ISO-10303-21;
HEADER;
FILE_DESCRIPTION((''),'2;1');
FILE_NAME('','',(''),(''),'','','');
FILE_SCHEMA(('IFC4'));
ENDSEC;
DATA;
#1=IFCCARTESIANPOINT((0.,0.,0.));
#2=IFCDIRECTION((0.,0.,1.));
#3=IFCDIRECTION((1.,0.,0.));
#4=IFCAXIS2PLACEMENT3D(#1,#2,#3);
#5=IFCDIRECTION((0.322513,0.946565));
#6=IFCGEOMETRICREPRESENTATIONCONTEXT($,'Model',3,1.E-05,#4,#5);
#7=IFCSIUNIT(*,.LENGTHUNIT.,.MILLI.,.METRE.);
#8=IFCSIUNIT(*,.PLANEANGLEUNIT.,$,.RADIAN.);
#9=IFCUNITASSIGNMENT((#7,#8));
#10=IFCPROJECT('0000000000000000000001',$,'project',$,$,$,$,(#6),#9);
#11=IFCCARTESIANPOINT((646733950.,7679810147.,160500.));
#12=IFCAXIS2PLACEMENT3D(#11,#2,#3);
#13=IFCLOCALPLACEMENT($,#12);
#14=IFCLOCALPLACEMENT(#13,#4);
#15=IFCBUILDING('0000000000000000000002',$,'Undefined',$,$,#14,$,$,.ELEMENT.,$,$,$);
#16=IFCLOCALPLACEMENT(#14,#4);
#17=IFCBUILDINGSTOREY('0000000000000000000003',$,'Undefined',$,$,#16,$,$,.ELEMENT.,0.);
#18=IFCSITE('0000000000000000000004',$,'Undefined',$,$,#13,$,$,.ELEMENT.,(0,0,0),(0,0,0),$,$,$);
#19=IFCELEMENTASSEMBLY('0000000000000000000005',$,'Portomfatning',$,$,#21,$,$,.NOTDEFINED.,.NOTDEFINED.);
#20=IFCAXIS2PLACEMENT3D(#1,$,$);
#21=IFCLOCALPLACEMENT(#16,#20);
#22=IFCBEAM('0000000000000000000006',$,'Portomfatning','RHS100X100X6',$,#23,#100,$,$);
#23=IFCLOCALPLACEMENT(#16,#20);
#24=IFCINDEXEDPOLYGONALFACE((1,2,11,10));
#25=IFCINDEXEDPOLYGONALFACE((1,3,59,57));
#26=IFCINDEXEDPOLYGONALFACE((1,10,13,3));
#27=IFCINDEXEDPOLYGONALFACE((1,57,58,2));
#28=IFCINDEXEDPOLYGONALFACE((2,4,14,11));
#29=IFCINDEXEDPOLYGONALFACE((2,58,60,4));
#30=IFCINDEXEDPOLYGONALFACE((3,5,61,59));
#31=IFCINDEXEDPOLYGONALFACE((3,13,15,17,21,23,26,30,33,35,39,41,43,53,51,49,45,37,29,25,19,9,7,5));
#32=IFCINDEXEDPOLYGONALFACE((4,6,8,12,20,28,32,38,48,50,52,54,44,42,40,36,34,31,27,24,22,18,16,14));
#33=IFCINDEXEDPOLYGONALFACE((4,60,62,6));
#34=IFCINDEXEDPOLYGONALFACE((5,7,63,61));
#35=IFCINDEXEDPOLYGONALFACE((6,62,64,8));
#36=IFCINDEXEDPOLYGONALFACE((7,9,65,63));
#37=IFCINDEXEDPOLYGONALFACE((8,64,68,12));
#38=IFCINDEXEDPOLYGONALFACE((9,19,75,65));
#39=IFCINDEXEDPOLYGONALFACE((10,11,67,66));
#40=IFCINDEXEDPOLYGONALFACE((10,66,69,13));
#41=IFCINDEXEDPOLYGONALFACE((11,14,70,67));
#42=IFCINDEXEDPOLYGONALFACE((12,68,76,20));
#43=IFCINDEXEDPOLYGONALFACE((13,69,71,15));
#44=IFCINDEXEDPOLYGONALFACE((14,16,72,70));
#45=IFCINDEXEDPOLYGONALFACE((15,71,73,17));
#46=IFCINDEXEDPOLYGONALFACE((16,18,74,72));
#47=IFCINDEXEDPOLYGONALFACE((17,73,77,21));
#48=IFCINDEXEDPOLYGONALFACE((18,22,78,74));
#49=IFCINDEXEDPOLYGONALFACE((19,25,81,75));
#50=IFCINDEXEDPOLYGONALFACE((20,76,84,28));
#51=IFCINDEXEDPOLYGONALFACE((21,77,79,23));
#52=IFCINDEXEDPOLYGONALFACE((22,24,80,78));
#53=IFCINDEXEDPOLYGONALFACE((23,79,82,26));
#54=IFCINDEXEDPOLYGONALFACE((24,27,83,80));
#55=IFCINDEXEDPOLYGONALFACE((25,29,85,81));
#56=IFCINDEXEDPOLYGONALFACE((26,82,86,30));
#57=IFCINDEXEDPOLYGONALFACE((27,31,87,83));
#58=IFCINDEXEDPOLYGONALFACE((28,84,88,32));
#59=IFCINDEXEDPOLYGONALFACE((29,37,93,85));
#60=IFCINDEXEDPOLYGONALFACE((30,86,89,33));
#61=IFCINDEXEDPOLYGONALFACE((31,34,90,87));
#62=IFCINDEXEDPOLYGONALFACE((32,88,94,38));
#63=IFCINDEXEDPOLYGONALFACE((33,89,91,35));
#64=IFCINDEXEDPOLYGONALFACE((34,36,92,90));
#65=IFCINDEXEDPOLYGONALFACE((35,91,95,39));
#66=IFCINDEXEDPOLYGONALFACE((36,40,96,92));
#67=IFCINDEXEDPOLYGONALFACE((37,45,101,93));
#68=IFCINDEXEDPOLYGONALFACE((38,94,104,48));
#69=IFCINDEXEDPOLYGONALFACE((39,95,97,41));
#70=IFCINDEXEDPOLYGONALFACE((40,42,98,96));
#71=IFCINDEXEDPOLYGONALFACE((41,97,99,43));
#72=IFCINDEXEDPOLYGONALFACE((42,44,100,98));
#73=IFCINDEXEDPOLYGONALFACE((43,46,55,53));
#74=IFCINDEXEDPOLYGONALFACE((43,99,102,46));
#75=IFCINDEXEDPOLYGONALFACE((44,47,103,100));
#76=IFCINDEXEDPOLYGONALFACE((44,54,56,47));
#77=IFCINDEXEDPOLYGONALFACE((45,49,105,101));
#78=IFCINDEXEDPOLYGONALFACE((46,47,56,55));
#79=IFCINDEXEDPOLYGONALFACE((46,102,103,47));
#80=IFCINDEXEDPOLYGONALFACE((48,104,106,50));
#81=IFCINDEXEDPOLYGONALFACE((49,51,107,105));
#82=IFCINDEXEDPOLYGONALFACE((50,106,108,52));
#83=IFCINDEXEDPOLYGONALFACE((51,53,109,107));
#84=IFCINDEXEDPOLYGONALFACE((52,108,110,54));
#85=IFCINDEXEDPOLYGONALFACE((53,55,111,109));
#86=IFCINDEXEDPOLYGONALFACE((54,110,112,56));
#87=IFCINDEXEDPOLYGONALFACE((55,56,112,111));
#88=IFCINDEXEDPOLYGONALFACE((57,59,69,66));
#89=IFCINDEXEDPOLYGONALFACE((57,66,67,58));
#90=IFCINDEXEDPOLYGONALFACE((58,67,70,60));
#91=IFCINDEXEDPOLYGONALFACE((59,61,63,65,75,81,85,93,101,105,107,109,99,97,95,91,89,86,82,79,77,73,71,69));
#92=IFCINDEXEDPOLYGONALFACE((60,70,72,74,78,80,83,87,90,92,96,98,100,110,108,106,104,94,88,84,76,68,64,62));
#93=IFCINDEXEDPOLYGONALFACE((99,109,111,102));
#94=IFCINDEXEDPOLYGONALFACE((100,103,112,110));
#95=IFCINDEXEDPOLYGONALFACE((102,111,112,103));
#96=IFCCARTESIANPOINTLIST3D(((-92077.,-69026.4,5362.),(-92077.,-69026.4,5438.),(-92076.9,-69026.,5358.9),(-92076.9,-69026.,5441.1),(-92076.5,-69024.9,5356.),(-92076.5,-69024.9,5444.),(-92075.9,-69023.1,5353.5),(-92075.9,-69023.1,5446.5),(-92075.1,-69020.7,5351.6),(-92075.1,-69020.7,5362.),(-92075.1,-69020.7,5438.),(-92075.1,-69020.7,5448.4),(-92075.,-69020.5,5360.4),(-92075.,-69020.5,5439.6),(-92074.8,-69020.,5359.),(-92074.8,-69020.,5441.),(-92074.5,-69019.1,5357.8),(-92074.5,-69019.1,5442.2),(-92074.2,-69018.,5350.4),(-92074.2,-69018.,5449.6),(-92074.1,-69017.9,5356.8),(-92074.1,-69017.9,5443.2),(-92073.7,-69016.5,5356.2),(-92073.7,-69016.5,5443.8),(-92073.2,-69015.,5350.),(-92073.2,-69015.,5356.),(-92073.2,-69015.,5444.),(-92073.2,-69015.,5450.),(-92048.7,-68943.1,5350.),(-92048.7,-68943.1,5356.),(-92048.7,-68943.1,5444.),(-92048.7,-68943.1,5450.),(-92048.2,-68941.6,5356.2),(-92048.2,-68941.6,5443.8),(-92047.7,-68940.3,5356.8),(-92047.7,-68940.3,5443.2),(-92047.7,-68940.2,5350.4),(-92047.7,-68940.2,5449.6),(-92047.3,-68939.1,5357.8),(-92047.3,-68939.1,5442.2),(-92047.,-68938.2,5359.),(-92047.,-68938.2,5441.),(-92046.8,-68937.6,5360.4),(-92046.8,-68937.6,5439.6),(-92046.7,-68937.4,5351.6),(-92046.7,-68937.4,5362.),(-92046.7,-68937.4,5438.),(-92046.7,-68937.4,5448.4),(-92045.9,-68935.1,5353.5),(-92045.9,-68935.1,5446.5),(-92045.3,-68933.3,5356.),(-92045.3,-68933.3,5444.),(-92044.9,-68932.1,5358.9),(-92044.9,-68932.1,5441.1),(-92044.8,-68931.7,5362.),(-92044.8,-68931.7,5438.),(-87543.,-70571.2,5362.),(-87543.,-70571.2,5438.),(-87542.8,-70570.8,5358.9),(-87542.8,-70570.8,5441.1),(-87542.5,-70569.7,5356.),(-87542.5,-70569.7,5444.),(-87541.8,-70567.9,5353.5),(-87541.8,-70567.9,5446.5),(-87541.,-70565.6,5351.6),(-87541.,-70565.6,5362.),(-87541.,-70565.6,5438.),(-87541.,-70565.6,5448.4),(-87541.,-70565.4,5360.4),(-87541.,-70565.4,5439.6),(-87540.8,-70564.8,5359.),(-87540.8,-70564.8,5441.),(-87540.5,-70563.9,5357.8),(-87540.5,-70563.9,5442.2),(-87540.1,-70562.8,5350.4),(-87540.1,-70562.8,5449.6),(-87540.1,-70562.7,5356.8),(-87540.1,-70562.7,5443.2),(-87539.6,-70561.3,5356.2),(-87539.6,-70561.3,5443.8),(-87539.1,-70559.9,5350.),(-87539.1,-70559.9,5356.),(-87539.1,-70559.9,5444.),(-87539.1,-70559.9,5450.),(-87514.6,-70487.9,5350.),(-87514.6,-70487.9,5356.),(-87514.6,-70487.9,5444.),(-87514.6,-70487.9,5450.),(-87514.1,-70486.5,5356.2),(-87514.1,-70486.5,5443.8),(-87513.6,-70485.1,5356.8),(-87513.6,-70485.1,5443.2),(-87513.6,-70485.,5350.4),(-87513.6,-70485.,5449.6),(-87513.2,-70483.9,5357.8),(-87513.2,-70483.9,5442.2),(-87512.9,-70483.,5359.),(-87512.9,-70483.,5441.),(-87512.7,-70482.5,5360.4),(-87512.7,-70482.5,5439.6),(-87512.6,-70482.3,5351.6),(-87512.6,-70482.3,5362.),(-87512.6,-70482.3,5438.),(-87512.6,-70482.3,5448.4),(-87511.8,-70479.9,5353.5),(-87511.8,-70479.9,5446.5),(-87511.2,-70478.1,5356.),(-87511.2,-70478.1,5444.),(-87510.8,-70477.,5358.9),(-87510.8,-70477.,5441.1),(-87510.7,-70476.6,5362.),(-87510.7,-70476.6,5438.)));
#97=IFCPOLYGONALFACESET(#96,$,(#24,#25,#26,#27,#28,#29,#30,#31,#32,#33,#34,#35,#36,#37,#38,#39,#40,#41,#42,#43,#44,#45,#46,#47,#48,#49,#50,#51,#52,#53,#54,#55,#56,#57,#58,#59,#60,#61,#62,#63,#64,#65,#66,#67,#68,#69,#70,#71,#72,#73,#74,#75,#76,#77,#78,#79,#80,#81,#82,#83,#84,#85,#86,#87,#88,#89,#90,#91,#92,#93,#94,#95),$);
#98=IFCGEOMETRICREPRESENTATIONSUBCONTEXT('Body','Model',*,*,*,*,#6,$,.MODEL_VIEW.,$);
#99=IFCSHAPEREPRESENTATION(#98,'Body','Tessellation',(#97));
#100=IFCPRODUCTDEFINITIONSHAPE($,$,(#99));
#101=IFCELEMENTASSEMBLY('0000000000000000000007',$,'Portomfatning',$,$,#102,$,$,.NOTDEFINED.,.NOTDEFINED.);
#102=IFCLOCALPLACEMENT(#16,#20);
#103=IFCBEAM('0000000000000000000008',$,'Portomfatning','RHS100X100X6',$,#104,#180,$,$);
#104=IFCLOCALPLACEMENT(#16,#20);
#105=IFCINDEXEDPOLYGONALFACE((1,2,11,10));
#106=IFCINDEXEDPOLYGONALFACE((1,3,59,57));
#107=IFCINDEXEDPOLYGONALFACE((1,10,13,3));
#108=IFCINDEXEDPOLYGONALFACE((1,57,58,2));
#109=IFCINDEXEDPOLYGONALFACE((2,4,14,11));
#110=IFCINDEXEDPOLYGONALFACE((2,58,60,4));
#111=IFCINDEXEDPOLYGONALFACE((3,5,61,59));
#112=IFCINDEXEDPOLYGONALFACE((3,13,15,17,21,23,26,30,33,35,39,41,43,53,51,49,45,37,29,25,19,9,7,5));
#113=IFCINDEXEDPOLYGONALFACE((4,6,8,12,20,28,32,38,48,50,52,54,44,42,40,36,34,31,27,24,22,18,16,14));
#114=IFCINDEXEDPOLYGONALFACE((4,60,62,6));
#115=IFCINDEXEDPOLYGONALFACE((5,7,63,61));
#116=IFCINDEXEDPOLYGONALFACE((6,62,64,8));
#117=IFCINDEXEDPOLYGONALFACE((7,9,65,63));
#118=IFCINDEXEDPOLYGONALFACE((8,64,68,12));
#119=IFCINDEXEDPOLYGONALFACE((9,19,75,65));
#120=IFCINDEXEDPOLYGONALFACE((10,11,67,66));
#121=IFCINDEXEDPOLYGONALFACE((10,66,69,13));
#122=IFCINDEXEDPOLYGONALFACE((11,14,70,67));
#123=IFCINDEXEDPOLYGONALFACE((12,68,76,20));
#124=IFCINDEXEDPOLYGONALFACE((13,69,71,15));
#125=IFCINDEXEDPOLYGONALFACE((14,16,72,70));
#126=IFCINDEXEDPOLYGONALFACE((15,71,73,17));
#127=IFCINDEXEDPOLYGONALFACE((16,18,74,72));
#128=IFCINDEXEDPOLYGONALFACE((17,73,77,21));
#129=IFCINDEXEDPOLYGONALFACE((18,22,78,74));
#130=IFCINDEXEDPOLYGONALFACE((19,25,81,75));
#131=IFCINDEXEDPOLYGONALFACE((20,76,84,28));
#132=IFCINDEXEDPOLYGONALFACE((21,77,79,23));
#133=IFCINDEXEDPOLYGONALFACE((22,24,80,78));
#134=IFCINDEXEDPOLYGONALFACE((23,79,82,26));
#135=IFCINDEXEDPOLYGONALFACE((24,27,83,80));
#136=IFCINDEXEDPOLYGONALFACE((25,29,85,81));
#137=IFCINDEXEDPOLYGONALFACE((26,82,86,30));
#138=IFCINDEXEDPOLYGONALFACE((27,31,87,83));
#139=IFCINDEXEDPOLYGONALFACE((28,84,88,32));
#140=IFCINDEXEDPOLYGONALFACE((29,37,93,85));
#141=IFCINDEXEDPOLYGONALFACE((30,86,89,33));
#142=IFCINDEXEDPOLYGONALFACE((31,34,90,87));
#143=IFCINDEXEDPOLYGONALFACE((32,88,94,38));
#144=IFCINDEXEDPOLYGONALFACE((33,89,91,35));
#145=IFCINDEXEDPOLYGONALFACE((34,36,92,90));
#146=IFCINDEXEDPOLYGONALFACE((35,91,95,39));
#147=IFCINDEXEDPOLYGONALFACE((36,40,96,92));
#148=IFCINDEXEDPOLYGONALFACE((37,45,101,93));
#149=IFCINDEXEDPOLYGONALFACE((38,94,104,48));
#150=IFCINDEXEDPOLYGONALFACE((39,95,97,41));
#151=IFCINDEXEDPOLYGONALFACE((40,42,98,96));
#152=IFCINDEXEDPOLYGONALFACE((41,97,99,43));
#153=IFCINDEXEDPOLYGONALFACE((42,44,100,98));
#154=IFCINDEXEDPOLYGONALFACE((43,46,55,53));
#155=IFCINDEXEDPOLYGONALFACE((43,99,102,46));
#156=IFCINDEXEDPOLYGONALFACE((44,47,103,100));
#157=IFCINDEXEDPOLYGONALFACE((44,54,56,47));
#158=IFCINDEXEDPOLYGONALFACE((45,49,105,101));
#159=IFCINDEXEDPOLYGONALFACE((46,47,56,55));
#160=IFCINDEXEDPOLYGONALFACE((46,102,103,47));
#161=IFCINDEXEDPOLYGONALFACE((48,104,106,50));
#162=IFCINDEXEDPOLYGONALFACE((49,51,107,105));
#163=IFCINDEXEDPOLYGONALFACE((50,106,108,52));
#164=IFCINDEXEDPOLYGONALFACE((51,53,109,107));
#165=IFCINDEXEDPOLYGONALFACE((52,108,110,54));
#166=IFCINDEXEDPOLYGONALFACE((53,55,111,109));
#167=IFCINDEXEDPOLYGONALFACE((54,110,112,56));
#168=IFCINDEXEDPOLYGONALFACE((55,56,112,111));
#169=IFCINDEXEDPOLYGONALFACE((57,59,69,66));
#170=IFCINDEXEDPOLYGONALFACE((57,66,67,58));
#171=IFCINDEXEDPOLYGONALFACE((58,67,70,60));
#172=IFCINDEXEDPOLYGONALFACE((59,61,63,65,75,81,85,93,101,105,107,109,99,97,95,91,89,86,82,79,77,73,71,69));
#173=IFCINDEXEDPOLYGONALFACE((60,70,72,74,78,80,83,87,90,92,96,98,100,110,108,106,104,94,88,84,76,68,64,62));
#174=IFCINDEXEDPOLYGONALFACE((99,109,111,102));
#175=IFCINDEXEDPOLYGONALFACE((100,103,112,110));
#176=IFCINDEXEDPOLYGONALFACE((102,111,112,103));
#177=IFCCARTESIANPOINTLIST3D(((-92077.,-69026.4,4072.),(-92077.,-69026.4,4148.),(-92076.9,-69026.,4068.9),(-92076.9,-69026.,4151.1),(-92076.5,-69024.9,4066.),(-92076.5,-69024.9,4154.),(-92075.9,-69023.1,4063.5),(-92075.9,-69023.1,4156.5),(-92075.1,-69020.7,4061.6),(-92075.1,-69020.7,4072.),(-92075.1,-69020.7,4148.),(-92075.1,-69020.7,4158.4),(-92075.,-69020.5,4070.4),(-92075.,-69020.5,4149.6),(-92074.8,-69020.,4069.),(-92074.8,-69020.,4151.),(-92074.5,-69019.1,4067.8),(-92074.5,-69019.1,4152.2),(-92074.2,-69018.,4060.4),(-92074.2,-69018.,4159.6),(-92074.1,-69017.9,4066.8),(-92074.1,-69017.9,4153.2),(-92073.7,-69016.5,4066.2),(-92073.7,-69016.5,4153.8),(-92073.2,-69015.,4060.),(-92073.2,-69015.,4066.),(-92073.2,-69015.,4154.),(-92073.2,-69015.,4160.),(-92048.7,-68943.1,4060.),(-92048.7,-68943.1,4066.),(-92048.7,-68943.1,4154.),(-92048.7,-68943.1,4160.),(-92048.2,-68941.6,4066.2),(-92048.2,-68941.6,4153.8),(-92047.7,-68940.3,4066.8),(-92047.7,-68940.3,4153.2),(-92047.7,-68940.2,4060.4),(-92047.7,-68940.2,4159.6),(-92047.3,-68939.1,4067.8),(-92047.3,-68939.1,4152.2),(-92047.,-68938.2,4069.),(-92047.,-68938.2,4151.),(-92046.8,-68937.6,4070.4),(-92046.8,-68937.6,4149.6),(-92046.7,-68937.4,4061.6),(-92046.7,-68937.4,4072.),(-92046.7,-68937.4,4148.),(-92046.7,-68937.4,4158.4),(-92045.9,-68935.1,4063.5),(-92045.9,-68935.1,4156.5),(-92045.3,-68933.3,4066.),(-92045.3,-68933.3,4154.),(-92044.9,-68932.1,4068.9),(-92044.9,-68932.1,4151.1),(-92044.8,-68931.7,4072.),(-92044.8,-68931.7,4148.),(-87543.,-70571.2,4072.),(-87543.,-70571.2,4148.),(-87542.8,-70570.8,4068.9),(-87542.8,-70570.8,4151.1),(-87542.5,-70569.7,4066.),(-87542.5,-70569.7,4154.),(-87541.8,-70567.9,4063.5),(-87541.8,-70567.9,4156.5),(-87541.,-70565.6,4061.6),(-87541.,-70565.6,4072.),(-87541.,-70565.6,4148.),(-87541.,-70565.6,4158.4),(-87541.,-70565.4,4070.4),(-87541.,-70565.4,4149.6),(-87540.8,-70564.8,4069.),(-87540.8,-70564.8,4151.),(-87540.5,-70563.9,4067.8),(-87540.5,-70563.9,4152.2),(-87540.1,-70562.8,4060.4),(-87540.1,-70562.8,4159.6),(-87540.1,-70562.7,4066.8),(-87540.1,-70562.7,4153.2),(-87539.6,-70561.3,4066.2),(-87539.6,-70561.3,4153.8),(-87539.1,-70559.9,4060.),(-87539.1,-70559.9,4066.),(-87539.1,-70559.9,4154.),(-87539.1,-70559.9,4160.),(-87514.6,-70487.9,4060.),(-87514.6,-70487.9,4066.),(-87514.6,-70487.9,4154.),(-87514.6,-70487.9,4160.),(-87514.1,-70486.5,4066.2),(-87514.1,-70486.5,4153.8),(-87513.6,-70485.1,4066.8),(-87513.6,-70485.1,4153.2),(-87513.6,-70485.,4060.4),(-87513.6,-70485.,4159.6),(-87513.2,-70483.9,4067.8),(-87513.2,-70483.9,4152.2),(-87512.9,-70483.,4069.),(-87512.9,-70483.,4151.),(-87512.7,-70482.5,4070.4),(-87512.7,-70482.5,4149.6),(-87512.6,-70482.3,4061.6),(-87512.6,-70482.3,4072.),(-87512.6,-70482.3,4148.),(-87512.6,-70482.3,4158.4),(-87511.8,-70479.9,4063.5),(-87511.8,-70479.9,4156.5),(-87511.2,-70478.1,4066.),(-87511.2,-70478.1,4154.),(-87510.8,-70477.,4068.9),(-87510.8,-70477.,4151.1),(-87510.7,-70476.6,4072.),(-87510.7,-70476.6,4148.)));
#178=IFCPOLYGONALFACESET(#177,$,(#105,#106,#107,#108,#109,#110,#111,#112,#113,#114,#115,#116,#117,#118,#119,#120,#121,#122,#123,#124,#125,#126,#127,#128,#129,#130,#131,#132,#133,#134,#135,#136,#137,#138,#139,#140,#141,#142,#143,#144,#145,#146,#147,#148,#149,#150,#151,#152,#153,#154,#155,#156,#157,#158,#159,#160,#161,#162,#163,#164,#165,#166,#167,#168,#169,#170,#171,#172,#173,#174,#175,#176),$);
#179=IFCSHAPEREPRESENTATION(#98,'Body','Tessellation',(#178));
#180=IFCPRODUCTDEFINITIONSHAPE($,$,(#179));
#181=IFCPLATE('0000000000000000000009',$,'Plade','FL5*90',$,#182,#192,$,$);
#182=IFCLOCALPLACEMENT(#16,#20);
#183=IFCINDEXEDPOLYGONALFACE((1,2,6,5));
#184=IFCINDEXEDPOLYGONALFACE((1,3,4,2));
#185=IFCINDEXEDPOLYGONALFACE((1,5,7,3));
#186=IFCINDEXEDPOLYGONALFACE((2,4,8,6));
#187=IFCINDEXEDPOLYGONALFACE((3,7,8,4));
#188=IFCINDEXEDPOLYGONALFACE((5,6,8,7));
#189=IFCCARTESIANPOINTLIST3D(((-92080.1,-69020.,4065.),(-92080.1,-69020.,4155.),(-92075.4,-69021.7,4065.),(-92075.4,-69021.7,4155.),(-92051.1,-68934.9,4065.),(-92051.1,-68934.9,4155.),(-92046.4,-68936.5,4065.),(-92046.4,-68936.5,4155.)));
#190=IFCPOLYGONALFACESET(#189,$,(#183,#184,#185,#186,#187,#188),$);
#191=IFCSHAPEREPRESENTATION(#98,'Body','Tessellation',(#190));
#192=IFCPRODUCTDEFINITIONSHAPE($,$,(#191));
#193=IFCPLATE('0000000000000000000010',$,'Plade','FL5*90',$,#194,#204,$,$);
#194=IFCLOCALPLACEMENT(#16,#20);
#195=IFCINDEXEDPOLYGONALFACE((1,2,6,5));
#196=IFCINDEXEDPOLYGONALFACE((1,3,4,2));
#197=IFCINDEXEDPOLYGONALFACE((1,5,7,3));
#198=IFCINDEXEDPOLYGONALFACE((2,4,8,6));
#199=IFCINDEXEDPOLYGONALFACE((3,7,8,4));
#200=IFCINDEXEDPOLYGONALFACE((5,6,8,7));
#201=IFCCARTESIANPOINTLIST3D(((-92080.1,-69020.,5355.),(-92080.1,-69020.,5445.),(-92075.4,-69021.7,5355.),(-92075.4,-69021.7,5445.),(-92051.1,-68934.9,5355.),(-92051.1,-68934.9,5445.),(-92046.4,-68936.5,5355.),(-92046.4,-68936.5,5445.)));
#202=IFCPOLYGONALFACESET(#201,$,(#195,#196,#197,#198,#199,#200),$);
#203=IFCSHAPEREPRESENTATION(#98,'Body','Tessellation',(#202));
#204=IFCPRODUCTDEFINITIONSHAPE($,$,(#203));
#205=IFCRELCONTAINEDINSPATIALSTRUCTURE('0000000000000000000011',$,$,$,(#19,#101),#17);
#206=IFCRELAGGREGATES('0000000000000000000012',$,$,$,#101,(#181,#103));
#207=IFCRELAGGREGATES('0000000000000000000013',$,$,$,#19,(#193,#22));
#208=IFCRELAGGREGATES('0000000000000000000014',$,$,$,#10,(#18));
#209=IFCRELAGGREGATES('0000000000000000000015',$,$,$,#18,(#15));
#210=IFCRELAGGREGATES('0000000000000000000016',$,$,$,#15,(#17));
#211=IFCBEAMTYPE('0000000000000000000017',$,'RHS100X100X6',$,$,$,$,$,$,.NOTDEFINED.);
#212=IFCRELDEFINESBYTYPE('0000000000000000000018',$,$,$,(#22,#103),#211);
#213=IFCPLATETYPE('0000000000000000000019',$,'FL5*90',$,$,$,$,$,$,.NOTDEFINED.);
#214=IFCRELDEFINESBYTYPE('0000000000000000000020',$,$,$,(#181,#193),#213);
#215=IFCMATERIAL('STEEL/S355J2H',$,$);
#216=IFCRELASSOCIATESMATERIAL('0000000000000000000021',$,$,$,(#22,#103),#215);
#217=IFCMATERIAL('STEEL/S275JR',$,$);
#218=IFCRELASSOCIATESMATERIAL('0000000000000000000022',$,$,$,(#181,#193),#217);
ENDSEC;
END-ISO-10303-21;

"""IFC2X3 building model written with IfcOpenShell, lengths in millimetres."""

from ifc_helpers import new_model, si_unit, direction, frame, origin_with_axes, origin_2d_with_axis, place, context, subcontext, project, spatial, polyline, hollow_rectangle, outline, extrude, clip, halfspace, material, type_object, element, aggregate, save


model = new_model("IFC2X3")

# Units and contexts
model_context = context("Model", 3, precision=1e-05, world=origin_with_axes(), true_north=direction((0.322513, 0.946565)))
body_context = subcontext(model_context, "Body", "Model", "MODEL_VIEW")
ifc_project = project(units=[si_unit("LENGTHUNIT", "METRE", prefix="MILLI"), si_unit("PLANEANGLEUNIT", "RADIAN")], contexts=[model_context])

# Site, building, storey
site_placement = place(None, frame((646733950.0, 7679810147.0, 160500.0), z_axis=(0.0, 0.0, 1.0), x_axis=(1.0, 0.0, 0.0)))
site = spatial("IfcSite", under=ifc_project, at=site_placement, Name="Undefined", CompositionType="ELEMENT", RefLatitude=(0, 0, 0), RefLongitude=(0, 0, 0))
building_placement = place(site_placement, origin_with_axes())
building = spatial("IfcBuilding", under=site, at=building_placement, Name="Undefined", CompositionType="ELEMENT")
storey_placement = place(building_placement, origin_with_axes())
storey = spatial("IfcBuildingStorey", under=building, at=storey_placement, Name="Undefined", CompositionType="ELEMENT", Elevation=0.0)

# Shared definitions
ifc_material_1 = material(Name="STEEL/S355J2H")

# Element assemblies, beams
assembly_1_placement = place(storey_placement, origin_with_axes())
assembly_1 = element("IfcElementAssembly", 1, at=assembly_1_placement, inside=storey, Name="Portomfatning", AssemblyPlace="NOTDEFINED", PredefinedType="NOTDEFINED")
beam_type = type_object("IfcBeamType", Name="RHS100X100X6", PredefinedType="NOTDEFINED")
beam_1_placement = place(assembly_1_placement, frame((-92075.1, -68974.2, 5400.0), z_axis=(0.322513, 0.946565, 0.0), x_axis=(0.946565, -0.322513, 0.0)))
beam_1 = element("IfcBeam", 2, at=beam_1_placement, type_object=beam_type, material=ifc_material_1, Name="Portomfatning", Description="RHS100X100X6", context=body_context, shape_type="Clipping", body=[
    clip(clip(extrude(hollow_rectangle(XDim=100.0, YDim=100.0, WallThickness=6.0, InnerFilletRadius=6.0, OuterFilletRadius=12.0, at=origin_2d_with_axis()), frame((4866.7, 0.0, 0.0), z_axis=(-1.0, 0.0, 0.0), x_axis=(0.0, -1.0, 0.0)), (0.0, 0.0, 1.0), 4913.4), halfspace(frame((4805.0, -50.0, -50.0), z_axis=(-1.0, 0.0, 0.000185), x_axis=(0.0, 1.0, 0.0)), True)), halfspace(frame((15.0, 50.0, -50.0), z_axis=(1.0, 0.0, 0.000185), x_axis=(0.0, -1.0, 0.0)), True)),
])
assembly_2_placement = place(storey_placement, origin_with_axes())
assembly_2 = element("IfcElementAssembly", 3, at=assembly_2_placement, inside=storey, Name="Portomfatning", AssemblyPlace="NOTDEFINED", PredefinedType="NOTDEFINED")
beam_2_placement = place(assembly_2_placement, frame((-92075.1, -68974.2, 4110.0), z_axis=(0.322513, 0.946565, 0.0), x_axis=(0.946565, -0.322513, 0.0)))
beam_2 = element("IfcBeam", 4, at=beam_2_placement, type_object=beam_type, material=ifc_material_1, Name="Portomfatning", Description="RHS100X100X6", context=body_context, shape_type="Clipping", body=[
    clip(clip(extrude(hollow_rectangle(XDim=100.0, YDim=100.0, WallThickness=6.0, InnerFilletRadius=6.0, OuterFilletRadius=12.0, at=origin_2d_with_axis()), frame((4866.7, 0.0, 0.0), z_axis=(-1.0, 0.0, 0.0), x_axis=(0.0, -1.0, 0.0)), (0.0, 0.0, 1.0), 4913.4), halfspace(frame((4805.0, -50.0, -50.0), z_axis=(-1.0, 0.0, 0.000185), x_axis=(0.0, 1.0, 0.0)), True)), halfspace(frame((15.0, 50.0, -50.0), z_axis=(1.0, 0.0, 0.000185), x_axis=(0.0, -1.0, 0.0)), True)),
])

# Plates
ifc_material_2 = material(Name="STEEL/S275JR")
plate_type_1 = type_object("IfcPlateType", Name="FL5*90", PredefinedType="NOTDEFINED")
plate_1_placement = place(assembly_2_placement, frame((-92048.8, -68935.7, 4155.0), z_axis=(-0.946625, 0.322338, 0.0), x_axis=(0.0, 0.0, -1.0)))
plate_1 = element("IfcPlate", 5, at=plate_1_placement, type_object=plate_type_1, material=ifc_material_2, Name="Plade", Description="FL5*90", context=body_context, shape_type="SweptSolid", body=[
    extrude(outline(polyline([(0.0, 0.0), (90.0, 0.0), (90.0, 90.0), (0.0, 90.0), (0.0, 0.0)])), frame((0.0, 0.0, -2.5), z_axis=(0.0, 0.0, 1.0), x_axis=(1.0, 0.0, 0.0)), (0.0, 0.0, 1.0), 5.0),
])
aggregate(assembly_2, [plate_1, beam_2])
plate_2_placement = place(assembly_1_placement, frame((-92048.8, -68935.7, 5445.0), z_axis=(-0.946625, 0.322338, 0.0), x_axis=(0.0, 0.0, -1.0)))
plate_2 = element("IfcPlate", 6, at=plate_2_placement, type_object=plate_type_1, material=ifc_material_2, Name="Plade", Description="FL5*90", context=body_context, shape_type="SweptSolid", body=[
    extrude(outline(polyline([(0.0, 0.0), (90.0, 0.0), (90.0, 90.0), (0.0, 90.0), (0.0, 0.0)])), frame((0.0, 0.0, -2.5), z_axis=(0.0, 0.0, 1.0), x_axis=(1.0, 0.0, 0.0)), (0.0, 0.0, 1.0), 5.0),
])
aggregate(assembly_1, [plate_2, beam_1])

save(model, "model.ifc")
